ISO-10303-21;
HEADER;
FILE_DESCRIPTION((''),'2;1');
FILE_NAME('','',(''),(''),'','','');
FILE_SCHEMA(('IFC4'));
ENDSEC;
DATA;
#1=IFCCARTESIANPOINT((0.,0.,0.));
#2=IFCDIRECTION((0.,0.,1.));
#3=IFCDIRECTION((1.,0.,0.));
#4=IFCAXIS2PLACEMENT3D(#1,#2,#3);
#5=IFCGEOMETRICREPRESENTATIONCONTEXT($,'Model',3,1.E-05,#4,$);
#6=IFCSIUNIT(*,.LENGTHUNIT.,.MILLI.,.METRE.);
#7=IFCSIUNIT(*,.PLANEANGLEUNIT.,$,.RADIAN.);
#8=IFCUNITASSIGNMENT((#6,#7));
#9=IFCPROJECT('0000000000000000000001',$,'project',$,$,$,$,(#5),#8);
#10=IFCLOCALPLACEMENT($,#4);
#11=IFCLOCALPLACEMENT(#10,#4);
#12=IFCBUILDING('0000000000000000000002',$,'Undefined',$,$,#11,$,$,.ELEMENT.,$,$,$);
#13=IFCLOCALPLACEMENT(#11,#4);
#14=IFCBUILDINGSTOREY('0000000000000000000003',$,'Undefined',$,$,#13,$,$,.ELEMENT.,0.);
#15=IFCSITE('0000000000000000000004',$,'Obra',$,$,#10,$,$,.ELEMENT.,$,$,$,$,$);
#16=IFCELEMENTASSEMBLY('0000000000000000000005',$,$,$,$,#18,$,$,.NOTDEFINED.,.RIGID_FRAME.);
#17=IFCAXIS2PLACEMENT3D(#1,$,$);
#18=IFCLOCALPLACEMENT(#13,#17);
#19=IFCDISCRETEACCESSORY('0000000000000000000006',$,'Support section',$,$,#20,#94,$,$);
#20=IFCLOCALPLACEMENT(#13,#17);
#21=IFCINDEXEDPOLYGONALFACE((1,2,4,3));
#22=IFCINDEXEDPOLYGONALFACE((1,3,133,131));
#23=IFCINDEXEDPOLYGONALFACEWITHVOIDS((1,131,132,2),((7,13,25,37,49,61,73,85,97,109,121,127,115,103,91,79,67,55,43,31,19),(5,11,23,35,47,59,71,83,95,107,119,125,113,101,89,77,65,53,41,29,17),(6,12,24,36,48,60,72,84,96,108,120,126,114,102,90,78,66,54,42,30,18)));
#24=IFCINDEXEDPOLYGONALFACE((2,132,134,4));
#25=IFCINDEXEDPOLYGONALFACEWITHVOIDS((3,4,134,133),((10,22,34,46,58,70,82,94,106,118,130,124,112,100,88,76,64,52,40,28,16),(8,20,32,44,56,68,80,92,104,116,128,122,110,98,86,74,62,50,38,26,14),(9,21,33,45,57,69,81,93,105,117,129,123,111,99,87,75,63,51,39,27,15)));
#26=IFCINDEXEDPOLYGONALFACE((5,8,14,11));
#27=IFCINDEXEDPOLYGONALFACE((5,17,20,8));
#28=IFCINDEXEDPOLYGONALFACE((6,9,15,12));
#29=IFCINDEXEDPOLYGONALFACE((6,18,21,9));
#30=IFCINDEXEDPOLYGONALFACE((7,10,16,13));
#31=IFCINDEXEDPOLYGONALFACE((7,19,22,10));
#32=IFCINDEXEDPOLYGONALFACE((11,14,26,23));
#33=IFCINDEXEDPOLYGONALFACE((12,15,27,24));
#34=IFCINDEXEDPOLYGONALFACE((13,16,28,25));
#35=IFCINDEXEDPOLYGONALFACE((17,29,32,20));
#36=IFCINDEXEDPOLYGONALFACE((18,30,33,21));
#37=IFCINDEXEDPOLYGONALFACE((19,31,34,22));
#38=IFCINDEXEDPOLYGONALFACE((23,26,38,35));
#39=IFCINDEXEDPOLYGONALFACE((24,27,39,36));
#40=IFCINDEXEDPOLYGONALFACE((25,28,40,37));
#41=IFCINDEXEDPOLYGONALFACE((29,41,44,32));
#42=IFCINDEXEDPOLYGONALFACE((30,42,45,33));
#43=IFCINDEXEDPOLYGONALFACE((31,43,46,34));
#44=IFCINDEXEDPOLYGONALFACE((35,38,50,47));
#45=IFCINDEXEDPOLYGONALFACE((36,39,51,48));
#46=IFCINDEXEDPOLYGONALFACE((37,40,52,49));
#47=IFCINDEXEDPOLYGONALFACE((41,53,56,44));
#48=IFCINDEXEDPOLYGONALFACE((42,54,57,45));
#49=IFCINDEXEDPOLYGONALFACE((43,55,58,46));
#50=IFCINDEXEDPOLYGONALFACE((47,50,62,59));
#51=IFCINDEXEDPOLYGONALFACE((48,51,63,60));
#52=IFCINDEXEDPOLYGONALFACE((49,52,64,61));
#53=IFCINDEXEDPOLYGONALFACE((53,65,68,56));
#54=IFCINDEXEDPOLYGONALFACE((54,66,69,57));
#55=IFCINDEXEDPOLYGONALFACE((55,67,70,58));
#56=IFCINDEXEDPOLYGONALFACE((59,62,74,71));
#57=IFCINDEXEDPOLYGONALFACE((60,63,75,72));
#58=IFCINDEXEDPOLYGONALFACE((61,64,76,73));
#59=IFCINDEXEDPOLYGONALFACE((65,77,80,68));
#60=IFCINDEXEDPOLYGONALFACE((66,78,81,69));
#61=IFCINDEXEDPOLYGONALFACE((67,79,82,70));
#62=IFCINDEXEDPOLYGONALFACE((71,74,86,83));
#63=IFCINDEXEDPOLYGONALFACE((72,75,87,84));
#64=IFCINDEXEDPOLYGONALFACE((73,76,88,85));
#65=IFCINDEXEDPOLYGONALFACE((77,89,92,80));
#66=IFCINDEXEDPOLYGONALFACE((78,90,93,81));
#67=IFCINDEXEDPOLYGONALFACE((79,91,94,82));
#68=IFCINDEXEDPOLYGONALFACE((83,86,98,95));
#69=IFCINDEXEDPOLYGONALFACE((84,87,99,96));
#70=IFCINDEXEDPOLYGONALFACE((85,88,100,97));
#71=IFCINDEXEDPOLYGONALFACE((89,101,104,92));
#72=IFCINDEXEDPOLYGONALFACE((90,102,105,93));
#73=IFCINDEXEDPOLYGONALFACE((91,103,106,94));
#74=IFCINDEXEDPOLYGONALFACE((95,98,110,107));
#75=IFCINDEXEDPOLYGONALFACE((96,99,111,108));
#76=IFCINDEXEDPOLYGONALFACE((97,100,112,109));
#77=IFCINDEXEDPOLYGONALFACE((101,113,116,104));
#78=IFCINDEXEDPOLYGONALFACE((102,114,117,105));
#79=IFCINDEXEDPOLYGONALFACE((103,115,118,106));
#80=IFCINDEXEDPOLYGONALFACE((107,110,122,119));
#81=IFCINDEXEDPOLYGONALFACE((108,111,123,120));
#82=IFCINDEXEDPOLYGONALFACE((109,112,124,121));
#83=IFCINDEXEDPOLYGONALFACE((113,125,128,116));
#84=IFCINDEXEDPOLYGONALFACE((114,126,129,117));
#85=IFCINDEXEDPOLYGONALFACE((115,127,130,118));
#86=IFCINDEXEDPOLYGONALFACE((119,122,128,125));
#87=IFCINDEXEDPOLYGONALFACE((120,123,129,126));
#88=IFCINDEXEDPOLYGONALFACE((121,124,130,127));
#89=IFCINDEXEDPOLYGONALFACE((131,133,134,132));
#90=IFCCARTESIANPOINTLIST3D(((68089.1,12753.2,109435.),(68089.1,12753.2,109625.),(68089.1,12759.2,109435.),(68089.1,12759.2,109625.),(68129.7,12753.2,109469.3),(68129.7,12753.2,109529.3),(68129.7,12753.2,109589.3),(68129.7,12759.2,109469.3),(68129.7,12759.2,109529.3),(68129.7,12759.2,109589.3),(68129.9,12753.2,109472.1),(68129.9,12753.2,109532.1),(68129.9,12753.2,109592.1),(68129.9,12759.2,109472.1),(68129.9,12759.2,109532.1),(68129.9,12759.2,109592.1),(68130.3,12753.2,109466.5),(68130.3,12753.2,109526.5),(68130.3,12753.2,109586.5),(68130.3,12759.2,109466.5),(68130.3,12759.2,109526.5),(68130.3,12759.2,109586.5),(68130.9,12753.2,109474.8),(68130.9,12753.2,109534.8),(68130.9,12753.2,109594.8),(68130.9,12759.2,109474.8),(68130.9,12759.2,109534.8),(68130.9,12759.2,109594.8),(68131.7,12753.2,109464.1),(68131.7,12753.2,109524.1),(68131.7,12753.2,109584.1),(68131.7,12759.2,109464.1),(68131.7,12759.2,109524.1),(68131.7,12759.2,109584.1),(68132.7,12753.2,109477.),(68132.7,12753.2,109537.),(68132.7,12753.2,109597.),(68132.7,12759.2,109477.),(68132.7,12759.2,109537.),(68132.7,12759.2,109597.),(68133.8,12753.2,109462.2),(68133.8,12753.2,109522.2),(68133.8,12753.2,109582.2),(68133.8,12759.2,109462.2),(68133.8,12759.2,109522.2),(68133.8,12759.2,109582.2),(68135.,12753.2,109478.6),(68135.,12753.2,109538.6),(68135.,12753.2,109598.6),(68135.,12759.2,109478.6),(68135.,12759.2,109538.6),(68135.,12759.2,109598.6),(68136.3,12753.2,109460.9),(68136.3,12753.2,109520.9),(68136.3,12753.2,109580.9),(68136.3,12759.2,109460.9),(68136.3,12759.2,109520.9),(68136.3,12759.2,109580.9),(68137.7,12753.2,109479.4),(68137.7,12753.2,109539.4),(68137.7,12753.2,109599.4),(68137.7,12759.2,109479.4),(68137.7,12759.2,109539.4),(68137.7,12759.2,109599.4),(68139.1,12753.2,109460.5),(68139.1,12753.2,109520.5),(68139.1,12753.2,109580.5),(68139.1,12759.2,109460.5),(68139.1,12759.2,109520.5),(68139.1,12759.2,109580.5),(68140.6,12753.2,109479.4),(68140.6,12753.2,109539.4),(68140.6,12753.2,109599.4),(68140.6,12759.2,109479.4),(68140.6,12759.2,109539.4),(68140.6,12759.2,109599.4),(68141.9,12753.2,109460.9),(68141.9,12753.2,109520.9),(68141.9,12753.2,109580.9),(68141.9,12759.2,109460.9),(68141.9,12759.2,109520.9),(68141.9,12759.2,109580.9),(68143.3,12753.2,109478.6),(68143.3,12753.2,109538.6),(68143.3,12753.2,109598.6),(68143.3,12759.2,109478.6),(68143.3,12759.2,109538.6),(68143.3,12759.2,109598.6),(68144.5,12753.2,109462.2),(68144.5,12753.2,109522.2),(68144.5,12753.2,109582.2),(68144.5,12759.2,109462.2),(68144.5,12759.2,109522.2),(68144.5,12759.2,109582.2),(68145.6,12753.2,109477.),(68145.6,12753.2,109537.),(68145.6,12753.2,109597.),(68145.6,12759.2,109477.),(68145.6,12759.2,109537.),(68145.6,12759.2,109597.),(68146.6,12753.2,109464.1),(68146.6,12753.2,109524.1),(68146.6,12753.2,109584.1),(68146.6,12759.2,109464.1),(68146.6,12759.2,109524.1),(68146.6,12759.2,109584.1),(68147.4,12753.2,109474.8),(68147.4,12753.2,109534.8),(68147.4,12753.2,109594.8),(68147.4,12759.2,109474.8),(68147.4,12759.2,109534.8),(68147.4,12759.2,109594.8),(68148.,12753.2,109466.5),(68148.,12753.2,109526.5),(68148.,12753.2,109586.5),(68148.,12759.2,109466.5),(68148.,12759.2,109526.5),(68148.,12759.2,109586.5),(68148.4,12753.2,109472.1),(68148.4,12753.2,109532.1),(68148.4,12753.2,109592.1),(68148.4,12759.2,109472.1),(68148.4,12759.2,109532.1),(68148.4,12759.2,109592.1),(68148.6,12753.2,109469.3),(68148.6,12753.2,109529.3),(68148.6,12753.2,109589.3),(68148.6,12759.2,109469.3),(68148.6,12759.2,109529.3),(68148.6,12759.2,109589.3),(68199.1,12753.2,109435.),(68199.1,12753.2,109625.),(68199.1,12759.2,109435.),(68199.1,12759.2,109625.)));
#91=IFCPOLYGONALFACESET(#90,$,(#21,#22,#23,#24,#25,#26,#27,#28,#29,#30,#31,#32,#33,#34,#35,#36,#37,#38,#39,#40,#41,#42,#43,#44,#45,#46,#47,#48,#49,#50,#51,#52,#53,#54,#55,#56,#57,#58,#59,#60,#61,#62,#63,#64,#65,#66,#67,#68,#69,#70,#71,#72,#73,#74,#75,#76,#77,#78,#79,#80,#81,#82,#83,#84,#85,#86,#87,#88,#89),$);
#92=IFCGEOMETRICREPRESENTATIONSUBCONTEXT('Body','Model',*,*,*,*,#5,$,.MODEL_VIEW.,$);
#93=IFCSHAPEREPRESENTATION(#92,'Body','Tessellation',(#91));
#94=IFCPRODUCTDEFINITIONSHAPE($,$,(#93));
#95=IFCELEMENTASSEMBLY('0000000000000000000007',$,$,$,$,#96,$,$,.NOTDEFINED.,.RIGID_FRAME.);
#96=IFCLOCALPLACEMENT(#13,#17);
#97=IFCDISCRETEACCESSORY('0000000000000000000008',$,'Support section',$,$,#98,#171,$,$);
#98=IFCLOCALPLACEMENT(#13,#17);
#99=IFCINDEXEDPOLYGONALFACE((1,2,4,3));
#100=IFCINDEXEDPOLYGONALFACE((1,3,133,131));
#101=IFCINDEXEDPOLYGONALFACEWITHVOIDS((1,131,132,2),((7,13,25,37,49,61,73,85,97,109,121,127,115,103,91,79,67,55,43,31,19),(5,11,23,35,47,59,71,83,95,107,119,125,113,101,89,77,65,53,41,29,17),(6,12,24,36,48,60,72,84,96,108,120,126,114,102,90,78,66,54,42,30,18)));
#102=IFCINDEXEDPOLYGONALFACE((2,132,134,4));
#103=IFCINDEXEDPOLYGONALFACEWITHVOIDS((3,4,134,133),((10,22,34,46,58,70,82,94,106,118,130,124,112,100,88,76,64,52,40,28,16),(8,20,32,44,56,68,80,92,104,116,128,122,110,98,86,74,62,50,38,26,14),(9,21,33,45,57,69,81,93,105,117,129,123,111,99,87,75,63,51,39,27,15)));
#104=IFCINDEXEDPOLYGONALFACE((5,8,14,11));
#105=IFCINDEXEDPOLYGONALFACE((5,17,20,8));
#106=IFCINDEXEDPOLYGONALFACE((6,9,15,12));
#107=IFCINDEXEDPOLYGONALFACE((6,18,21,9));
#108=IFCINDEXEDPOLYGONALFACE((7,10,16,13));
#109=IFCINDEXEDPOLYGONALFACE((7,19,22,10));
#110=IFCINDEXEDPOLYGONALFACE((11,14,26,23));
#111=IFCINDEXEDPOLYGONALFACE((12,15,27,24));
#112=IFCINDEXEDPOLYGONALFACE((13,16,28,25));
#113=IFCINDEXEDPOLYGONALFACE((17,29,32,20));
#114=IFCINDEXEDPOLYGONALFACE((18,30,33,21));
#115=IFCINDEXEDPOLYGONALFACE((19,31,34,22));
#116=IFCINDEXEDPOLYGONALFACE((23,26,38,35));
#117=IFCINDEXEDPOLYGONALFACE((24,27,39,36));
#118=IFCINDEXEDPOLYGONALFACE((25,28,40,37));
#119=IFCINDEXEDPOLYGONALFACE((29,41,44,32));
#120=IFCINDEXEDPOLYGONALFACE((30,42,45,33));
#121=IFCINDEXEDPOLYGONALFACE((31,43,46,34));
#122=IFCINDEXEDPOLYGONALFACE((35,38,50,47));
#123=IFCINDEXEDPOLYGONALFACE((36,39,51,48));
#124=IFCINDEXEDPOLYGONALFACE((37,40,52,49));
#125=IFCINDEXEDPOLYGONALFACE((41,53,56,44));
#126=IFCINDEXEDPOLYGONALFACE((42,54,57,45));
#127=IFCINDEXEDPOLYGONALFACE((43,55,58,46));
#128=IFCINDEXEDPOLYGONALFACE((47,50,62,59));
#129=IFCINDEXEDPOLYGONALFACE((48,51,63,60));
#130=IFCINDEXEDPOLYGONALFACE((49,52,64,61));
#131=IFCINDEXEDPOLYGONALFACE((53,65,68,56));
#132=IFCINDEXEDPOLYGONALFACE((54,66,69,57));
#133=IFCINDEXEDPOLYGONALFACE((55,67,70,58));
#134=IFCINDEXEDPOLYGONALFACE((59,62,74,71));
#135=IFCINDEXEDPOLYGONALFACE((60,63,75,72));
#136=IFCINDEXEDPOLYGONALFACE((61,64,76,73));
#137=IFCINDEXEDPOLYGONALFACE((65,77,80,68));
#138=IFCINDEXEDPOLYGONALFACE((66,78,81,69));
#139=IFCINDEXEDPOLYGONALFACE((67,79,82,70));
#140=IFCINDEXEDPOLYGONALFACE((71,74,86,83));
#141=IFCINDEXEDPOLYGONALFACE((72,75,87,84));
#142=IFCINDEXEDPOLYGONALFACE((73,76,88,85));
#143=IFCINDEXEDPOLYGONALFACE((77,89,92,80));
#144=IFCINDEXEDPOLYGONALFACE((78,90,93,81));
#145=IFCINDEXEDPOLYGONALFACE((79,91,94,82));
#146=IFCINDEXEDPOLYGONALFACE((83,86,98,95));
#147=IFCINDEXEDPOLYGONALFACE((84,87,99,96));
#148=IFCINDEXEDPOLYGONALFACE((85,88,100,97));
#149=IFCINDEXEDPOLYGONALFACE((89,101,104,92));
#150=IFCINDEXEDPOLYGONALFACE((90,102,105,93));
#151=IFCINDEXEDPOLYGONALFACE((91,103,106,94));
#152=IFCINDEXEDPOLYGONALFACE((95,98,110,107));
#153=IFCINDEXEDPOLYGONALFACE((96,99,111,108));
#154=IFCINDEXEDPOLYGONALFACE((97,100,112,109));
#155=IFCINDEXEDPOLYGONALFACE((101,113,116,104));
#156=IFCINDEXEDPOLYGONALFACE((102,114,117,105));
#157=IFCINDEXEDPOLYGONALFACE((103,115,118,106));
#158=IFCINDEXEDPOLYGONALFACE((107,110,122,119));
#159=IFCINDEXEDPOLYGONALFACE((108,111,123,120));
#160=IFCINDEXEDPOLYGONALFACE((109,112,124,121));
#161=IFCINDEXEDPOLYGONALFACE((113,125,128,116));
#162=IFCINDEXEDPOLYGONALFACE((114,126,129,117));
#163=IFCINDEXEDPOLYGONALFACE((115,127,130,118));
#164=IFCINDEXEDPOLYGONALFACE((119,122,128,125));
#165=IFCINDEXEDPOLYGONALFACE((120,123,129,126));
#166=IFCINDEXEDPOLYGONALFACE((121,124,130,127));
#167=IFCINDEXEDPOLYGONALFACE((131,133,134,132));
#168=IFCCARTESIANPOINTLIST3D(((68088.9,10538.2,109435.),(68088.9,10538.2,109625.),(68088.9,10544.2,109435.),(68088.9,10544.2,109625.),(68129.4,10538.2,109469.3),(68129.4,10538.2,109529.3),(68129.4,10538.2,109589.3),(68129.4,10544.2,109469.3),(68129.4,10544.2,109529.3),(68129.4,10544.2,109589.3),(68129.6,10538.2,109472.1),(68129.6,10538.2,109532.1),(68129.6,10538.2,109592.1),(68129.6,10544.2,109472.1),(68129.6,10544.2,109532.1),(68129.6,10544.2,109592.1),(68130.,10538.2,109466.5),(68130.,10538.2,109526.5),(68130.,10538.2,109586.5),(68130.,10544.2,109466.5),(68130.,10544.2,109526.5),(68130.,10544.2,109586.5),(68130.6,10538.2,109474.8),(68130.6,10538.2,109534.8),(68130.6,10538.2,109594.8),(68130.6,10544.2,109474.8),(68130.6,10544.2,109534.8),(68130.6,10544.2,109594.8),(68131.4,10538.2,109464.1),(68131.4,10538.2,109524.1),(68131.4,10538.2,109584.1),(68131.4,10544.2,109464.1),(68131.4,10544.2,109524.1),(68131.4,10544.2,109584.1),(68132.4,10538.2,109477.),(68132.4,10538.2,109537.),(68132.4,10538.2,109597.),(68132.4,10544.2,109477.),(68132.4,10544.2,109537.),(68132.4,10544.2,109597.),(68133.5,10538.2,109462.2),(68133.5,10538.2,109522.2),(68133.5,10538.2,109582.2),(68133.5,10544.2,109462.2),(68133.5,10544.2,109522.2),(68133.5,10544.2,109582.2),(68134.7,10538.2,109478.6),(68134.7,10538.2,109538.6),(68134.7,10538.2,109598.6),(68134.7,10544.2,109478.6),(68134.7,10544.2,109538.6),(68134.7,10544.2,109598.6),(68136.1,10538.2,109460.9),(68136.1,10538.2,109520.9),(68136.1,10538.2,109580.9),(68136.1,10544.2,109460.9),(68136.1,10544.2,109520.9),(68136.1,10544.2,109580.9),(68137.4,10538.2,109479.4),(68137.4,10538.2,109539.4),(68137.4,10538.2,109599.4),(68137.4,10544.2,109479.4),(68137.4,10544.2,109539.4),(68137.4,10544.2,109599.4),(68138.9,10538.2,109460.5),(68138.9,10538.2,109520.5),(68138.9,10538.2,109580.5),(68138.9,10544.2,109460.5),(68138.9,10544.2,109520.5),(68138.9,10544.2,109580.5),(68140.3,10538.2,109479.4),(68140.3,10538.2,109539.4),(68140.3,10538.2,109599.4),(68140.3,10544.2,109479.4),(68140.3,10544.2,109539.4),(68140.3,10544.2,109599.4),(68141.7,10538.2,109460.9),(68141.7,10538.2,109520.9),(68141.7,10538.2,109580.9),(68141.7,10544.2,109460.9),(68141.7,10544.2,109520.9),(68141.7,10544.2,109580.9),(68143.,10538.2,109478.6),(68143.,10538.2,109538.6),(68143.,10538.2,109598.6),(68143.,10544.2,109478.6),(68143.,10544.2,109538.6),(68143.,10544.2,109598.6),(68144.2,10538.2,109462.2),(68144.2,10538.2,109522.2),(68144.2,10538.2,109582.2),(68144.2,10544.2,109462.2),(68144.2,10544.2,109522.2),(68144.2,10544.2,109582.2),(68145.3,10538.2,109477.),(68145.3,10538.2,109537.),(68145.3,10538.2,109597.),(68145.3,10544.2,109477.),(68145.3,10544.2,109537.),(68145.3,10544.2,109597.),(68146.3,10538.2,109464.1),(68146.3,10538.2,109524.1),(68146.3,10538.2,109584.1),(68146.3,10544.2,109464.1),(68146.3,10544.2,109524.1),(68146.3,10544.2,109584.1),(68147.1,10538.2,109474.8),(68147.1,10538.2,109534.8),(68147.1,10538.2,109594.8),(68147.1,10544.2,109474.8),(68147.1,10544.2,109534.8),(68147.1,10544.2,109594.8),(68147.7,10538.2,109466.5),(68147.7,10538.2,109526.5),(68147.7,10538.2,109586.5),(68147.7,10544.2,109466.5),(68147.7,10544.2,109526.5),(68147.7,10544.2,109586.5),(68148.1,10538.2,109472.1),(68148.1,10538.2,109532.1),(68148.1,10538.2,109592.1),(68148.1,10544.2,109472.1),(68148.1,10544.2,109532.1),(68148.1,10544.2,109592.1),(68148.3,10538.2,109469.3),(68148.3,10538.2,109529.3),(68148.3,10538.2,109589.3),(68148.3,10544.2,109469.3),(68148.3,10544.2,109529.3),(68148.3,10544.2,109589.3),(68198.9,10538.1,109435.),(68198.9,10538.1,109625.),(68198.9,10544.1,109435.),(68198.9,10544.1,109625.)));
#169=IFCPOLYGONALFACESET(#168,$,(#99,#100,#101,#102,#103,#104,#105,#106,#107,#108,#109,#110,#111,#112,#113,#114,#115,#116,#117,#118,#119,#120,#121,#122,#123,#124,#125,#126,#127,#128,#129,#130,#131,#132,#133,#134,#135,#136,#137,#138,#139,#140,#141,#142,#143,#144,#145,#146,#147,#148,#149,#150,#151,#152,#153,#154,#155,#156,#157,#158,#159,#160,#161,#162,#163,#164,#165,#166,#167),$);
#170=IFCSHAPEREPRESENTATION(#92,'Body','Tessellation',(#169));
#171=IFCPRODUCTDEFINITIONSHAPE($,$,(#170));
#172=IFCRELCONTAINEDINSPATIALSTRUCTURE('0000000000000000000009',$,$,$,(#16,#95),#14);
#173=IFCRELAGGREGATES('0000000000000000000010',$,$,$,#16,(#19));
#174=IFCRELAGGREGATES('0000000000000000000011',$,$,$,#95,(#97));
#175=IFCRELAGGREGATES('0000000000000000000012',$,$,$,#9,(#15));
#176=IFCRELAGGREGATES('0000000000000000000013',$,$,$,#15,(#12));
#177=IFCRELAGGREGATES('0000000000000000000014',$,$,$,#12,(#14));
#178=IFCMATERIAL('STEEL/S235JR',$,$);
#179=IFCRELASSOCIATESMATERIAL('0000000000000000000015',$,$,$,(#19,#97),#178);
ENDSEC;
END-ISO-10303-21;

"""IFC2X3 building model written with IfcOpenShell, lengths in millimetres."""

from ifc_helpers import new_model, si_unit, frame, origin_with_axes, origin_2d_with_axis, place, context, subcontext, project, spatial, rectangle, circle, extrude, source, transform, mapped, material, element, aggregate, save


model = new_model("IFC2X3")

# Units and contexts
model_context = context("Model", 3, precision=1e-05, world=origin_with_axes())
body_context = subcontext(model_context, "Body", "Model", "MODEL_VIEW")
ifc_project = project(units=[si_unit("LENGTHUNIT", "METRE", prefix="MILLI"), si_unit("PLANEANGLEUNIT", "RADIAN")], contexts=[model_context])

# Site, building, storey
site_placement = place(None, origin_with_axes())
site = spatial("IfcSite", under=ifc_project, at=site_placement, Name="Obra", CompositionType="ELEMENT")
building_placement = place(site_placement, origin_with_axes())
building = spatial("IfcBuilding", under=site, at=building_placement, Name="Undefined", CompositionType="ELEMENT")
storey_placement = place(building_placement, origin_with_axes())
storey = spatial("IfcBuildingStorey", under=building, at=storey_placement, Name="Undefined", CompositionType="ELEMENT", Elevation=0.0)

# Shared definitions
ifc_material_1 = material(Name="STEEL/S235JR")

# Element assemblies, discrete accessories, openings
shared_shape_1 = source(origin_with_axes(), body_context, "Body", "SweptSolid", [
    extrude(circle(Radius=9.5, at=origin_2d_with_axis()), frame((0.0, -9.2, 0.0), z_axis=(0.0, 1.0, 0.0), x_axis=(1.0, 0.0, 0.0)), (0.0, 0.0, 1.0), 6.2),
])
assembly_1_placement = place(storey_placement, origin_with_axes())
assembly_1 = element("IfcElementAssembly", 1, at=assembly_1_placement, inside=storey, AssemblyPlace="NOTDEFINED", PredefinedType="RIGID_FRAME")
discrete_accessory_1_placement = place(assembly_1_placement, frame((68144.1, 12756.2, 109435.0), z_axis=(0.0, 0.0, 1.0), x_axis=(1.0, -0.000126, 0.0)))
discrete_accessory_1 = element("IfcDiscreteAccessory", 2, at=discrete_accessory_1_placement, material=ifc_material_1, Name="Support section", context=body_context, shape_type="SweptSolid", body=[
    extrude(rectangle(XDim=6.0, YDim=110.0, at=origin_2d_with_axis()), frame((0.0, 0.0, 190.0), z_axis=(0.0, 0.0, -1.0), x_axis=(0.0, 1.0, 0.0)), (0.0, 0.0, 1.0), 190.0),
])
opening_1_placement = place(assembly_1_placement, frame((68189.1, 12750.1, 109650.0), z_axis=(-1.0, 0.000126, 0.0), x_axis=(0.0, 0.0, -1.0)))
element("IfcOpeningElement", 3, at=opening_1_placement, cuts=discrete_accessory_1, ObjectType="Opening", context=body_context, shape_type="MappedRepresentation", body=[
    mapped(shared_shape_1, transform((60.0, 0.0, 50.0))),
    mapped(shared_shape_1, transform((120.0, 0.0, 50.0))),
    mapped(shared_shape_1, transform((180.0, 0.0, 50.0))),
])
aggregate(assembly_1, [discrete_accessory_1])
assembly_2_placement = place(storey_placement, origin_with_axes())
assembly_2 = element("IfcElementAssembly", 4, at=assembly_2_placement, inside=storey, AssemblyPlace="NOTDEFINED", PredefinedType="RIGID_FRAME")
discrete_accessory_2_placement = place(assembly_2_placement, frame((68143.9, 10541.2, 109435.0), z_axis=(0.0, 0.0, 1.0), x_axis=(1.0, -0.000126, 0.0)))
discrete_accessory_2 = element("IfcDiscreteAccessory", 5, at=discrete_accessory_2_placement, material=ifc_material_1, Name="Support section", context=body_context, shape_type="SweptSolid", body=[
    extrude(rectangle(XDim=6.0, YDim=110.0, at=origin_2d_with_axis()), frame((0.0, 0.0, 190.0), z_axis=(0.0, 0.0, -1.0), x_axis=(0.0, 1.0, 0.0)), (0.0, 0.0, 1.0), 190.0),
])
opening_2_placement = place(assembly_2_placement, frame((68188.9, 10535.0, 109650.0), z_axis=(-1.0, 0.000126, 0.0), x_axis=(0.0, 0.0, -1.0)))
element("IfcOpeningElement", 6, at=opening_2_placement, cuts=discrete_accessory_2, ObjectType="Opening", context=body_context, shape_type="MappedRepresentation", body=[
    mapped(shared_shape_1, transform((60.0, 0.0, 50.0))),
    mapped(shared_shape_1, transform((120.0, 0.0, 50.0))),
    mapped(shared_shape_1, transform((180.0, 0.0, 50.0))),
])
aggregate(assembly_2, [discrete_accessory_2])

save(model, "model.ifc")
